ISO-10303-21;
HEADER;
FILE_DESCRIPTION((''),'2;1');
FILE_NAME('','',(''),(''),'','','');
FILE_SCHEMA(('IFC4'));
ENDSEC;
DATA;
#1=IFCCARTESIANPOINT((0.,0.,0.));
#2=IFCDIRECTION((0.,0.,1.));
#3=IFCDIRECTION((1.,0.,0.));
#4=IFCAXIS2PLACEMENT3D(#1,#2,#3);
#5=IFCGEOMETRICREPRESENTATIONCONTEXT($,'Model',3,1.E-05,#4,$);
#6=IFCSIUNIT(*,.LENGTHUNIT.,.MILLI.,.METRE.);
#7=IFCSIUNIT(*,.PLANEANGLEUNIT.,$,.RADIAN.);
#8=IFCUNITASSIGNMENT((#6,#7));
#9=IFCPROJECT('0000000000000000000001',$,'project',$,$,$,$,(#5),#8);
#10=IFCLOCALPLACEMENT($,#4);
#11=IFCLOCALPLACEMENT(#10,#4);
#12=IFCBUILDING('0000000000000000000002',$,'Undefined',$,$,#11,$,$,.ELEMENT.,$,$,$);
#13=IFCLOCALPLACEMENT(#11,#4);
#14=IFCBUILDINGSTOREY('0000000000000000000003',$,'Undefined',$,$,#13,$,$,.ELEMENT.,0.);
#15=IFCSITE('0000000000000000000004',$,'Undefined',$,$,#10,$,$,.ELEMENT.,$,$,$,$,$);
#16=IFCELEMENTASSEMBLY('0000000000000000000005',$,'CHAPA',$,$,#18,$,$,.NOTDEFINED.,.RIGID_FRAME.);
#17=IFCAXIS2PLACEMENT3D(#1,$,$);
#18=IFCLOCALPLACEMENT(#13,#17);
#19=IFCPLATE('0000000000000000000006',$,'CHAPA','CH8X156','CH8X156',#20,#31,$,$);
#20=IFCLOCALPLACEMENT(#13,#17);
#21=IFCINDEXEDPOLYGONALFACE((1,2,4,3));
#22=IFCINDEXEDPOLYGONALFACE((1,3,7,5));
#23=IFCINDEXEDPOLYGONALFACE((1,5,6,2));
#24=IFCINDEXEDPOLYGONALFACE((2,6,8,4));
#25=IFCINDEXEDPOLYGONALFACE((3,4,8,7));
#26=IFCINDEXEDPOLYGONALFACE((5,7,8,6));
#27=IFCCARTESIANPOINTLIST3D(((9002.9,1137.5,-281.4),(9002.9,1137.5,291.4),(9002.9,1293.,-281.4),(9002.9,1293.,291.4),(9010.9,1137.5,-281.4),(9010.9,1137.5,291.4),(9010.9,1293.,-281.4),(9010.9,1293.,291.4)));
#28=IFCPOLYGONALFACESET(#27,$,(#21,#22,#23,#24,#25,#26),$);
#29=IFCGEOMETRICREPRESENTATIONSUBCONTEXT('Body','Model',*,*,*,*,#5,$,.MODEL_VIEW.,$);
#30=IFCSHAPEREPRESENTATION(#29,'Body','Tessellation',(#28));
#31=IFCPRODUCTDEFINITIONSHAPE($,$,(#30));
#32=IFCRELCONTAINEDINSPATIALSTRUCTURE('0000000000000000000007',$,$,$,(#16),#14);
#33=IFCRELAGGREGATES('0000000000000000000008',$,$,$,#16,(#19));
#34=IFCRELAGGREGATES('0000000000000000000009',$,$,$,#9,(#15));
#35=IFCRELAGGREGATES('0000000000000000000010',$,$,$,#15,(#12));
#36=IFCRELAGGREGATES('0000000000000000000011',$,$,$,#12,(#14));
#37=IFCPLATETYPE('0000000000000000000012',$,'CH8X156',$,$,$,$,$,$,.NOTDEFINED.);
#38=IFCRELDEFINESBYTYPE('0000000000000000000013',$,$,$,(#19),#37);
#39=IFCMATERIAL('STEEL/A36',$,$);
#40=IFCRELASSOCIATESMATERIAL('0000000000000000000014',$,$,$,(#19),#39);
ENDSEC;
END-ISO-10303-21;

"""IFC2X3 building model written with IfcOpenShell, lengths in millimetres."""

from ifc_helpers import new_model, si_unit, frame, origin_with_axes, place, context, subcontext, project, spatial, polyline, outline, extrude, material, type_object, element, aggregate, save


model = new_model("IFC2X3")

# Units and contexts
model_context = context("Model", 3, precision=1e-05, world=origin_with_axes())
body_context = subcontext(model_context, "Body", "Model", "MODEL_VIEW")
ifc_project = project(units=[si_unit("LENGTHUNIT", "METRE", prefix="MILLI"), si_unit("PLANEANGLEUNIT", "RADIAN")], contexts=[model_context])

# Site, building, storey
site_placement = place(None, origin_with_axes())
site = spatial("IfcSite", under=ifc_project, at=site_placement, Name="Undefined", CompositionType="ELEMENT")
building_placement = place(site_placement, origin_with_axes())
building = spatial("IfcBuilding", under=site, at=building_placement, Name="Undefined", CompositionType="ELEMENT")
storey_placement = place(building_placement, origin_with_axes())
storey = spatial("IfcBuildingStorey", under=building, at=storey_placement, Name="Undefined", CompositionType="ELEMENT", Elevation=0.0)

# Element assembly, plate
ifc_material_1 = material(Name="STEEL/A36")
plate_type = type_object("IfcPlateType", Name="CH8X156", PredefinedType="NOTDEFINED")
assembly_1_placement = place(storey_placement, origin_with_axes())
assembly_1 = element("IfcElementAssembly", 1, at=assembly_1_placement, inside=storey, Name="CHAPA", AssemblyPlace="NOTDEFINED", PredefinedType="RIGID_FRAME")
plate_1_placement = place(assembly_1_placement, frame((9006.9, 1293.0, 291.4), z_axis=(1.0, 0.0, 0.0), x_axis=(0.0, -1.0, 0.0)))
plate_1 = element("IfcPlate", 2, at=plate_1_placement, type_object=plate_type, material=ifc_material_1, Name="CHAPA", Description="CH8X156", ObjectType="CH8X156", context=body_context, shape_type="SweptSolid", body=[
    extrude(outline(polyline([(0.0, 0.0), (155.5, 0.0), (155.5, 572.8), (0.0, 572.8), (0.0, 0.0)])), frame((0.0, 0.0, -4.0), z_axis=(0.0, 0.0, 1.0), x_axis=(1.0, 0.0, 0.0)), (0.0, 0.0, 1.0), 8.0),
])
aggregate(assembly_1, [plate_1])

save(model, "model.ifc")
